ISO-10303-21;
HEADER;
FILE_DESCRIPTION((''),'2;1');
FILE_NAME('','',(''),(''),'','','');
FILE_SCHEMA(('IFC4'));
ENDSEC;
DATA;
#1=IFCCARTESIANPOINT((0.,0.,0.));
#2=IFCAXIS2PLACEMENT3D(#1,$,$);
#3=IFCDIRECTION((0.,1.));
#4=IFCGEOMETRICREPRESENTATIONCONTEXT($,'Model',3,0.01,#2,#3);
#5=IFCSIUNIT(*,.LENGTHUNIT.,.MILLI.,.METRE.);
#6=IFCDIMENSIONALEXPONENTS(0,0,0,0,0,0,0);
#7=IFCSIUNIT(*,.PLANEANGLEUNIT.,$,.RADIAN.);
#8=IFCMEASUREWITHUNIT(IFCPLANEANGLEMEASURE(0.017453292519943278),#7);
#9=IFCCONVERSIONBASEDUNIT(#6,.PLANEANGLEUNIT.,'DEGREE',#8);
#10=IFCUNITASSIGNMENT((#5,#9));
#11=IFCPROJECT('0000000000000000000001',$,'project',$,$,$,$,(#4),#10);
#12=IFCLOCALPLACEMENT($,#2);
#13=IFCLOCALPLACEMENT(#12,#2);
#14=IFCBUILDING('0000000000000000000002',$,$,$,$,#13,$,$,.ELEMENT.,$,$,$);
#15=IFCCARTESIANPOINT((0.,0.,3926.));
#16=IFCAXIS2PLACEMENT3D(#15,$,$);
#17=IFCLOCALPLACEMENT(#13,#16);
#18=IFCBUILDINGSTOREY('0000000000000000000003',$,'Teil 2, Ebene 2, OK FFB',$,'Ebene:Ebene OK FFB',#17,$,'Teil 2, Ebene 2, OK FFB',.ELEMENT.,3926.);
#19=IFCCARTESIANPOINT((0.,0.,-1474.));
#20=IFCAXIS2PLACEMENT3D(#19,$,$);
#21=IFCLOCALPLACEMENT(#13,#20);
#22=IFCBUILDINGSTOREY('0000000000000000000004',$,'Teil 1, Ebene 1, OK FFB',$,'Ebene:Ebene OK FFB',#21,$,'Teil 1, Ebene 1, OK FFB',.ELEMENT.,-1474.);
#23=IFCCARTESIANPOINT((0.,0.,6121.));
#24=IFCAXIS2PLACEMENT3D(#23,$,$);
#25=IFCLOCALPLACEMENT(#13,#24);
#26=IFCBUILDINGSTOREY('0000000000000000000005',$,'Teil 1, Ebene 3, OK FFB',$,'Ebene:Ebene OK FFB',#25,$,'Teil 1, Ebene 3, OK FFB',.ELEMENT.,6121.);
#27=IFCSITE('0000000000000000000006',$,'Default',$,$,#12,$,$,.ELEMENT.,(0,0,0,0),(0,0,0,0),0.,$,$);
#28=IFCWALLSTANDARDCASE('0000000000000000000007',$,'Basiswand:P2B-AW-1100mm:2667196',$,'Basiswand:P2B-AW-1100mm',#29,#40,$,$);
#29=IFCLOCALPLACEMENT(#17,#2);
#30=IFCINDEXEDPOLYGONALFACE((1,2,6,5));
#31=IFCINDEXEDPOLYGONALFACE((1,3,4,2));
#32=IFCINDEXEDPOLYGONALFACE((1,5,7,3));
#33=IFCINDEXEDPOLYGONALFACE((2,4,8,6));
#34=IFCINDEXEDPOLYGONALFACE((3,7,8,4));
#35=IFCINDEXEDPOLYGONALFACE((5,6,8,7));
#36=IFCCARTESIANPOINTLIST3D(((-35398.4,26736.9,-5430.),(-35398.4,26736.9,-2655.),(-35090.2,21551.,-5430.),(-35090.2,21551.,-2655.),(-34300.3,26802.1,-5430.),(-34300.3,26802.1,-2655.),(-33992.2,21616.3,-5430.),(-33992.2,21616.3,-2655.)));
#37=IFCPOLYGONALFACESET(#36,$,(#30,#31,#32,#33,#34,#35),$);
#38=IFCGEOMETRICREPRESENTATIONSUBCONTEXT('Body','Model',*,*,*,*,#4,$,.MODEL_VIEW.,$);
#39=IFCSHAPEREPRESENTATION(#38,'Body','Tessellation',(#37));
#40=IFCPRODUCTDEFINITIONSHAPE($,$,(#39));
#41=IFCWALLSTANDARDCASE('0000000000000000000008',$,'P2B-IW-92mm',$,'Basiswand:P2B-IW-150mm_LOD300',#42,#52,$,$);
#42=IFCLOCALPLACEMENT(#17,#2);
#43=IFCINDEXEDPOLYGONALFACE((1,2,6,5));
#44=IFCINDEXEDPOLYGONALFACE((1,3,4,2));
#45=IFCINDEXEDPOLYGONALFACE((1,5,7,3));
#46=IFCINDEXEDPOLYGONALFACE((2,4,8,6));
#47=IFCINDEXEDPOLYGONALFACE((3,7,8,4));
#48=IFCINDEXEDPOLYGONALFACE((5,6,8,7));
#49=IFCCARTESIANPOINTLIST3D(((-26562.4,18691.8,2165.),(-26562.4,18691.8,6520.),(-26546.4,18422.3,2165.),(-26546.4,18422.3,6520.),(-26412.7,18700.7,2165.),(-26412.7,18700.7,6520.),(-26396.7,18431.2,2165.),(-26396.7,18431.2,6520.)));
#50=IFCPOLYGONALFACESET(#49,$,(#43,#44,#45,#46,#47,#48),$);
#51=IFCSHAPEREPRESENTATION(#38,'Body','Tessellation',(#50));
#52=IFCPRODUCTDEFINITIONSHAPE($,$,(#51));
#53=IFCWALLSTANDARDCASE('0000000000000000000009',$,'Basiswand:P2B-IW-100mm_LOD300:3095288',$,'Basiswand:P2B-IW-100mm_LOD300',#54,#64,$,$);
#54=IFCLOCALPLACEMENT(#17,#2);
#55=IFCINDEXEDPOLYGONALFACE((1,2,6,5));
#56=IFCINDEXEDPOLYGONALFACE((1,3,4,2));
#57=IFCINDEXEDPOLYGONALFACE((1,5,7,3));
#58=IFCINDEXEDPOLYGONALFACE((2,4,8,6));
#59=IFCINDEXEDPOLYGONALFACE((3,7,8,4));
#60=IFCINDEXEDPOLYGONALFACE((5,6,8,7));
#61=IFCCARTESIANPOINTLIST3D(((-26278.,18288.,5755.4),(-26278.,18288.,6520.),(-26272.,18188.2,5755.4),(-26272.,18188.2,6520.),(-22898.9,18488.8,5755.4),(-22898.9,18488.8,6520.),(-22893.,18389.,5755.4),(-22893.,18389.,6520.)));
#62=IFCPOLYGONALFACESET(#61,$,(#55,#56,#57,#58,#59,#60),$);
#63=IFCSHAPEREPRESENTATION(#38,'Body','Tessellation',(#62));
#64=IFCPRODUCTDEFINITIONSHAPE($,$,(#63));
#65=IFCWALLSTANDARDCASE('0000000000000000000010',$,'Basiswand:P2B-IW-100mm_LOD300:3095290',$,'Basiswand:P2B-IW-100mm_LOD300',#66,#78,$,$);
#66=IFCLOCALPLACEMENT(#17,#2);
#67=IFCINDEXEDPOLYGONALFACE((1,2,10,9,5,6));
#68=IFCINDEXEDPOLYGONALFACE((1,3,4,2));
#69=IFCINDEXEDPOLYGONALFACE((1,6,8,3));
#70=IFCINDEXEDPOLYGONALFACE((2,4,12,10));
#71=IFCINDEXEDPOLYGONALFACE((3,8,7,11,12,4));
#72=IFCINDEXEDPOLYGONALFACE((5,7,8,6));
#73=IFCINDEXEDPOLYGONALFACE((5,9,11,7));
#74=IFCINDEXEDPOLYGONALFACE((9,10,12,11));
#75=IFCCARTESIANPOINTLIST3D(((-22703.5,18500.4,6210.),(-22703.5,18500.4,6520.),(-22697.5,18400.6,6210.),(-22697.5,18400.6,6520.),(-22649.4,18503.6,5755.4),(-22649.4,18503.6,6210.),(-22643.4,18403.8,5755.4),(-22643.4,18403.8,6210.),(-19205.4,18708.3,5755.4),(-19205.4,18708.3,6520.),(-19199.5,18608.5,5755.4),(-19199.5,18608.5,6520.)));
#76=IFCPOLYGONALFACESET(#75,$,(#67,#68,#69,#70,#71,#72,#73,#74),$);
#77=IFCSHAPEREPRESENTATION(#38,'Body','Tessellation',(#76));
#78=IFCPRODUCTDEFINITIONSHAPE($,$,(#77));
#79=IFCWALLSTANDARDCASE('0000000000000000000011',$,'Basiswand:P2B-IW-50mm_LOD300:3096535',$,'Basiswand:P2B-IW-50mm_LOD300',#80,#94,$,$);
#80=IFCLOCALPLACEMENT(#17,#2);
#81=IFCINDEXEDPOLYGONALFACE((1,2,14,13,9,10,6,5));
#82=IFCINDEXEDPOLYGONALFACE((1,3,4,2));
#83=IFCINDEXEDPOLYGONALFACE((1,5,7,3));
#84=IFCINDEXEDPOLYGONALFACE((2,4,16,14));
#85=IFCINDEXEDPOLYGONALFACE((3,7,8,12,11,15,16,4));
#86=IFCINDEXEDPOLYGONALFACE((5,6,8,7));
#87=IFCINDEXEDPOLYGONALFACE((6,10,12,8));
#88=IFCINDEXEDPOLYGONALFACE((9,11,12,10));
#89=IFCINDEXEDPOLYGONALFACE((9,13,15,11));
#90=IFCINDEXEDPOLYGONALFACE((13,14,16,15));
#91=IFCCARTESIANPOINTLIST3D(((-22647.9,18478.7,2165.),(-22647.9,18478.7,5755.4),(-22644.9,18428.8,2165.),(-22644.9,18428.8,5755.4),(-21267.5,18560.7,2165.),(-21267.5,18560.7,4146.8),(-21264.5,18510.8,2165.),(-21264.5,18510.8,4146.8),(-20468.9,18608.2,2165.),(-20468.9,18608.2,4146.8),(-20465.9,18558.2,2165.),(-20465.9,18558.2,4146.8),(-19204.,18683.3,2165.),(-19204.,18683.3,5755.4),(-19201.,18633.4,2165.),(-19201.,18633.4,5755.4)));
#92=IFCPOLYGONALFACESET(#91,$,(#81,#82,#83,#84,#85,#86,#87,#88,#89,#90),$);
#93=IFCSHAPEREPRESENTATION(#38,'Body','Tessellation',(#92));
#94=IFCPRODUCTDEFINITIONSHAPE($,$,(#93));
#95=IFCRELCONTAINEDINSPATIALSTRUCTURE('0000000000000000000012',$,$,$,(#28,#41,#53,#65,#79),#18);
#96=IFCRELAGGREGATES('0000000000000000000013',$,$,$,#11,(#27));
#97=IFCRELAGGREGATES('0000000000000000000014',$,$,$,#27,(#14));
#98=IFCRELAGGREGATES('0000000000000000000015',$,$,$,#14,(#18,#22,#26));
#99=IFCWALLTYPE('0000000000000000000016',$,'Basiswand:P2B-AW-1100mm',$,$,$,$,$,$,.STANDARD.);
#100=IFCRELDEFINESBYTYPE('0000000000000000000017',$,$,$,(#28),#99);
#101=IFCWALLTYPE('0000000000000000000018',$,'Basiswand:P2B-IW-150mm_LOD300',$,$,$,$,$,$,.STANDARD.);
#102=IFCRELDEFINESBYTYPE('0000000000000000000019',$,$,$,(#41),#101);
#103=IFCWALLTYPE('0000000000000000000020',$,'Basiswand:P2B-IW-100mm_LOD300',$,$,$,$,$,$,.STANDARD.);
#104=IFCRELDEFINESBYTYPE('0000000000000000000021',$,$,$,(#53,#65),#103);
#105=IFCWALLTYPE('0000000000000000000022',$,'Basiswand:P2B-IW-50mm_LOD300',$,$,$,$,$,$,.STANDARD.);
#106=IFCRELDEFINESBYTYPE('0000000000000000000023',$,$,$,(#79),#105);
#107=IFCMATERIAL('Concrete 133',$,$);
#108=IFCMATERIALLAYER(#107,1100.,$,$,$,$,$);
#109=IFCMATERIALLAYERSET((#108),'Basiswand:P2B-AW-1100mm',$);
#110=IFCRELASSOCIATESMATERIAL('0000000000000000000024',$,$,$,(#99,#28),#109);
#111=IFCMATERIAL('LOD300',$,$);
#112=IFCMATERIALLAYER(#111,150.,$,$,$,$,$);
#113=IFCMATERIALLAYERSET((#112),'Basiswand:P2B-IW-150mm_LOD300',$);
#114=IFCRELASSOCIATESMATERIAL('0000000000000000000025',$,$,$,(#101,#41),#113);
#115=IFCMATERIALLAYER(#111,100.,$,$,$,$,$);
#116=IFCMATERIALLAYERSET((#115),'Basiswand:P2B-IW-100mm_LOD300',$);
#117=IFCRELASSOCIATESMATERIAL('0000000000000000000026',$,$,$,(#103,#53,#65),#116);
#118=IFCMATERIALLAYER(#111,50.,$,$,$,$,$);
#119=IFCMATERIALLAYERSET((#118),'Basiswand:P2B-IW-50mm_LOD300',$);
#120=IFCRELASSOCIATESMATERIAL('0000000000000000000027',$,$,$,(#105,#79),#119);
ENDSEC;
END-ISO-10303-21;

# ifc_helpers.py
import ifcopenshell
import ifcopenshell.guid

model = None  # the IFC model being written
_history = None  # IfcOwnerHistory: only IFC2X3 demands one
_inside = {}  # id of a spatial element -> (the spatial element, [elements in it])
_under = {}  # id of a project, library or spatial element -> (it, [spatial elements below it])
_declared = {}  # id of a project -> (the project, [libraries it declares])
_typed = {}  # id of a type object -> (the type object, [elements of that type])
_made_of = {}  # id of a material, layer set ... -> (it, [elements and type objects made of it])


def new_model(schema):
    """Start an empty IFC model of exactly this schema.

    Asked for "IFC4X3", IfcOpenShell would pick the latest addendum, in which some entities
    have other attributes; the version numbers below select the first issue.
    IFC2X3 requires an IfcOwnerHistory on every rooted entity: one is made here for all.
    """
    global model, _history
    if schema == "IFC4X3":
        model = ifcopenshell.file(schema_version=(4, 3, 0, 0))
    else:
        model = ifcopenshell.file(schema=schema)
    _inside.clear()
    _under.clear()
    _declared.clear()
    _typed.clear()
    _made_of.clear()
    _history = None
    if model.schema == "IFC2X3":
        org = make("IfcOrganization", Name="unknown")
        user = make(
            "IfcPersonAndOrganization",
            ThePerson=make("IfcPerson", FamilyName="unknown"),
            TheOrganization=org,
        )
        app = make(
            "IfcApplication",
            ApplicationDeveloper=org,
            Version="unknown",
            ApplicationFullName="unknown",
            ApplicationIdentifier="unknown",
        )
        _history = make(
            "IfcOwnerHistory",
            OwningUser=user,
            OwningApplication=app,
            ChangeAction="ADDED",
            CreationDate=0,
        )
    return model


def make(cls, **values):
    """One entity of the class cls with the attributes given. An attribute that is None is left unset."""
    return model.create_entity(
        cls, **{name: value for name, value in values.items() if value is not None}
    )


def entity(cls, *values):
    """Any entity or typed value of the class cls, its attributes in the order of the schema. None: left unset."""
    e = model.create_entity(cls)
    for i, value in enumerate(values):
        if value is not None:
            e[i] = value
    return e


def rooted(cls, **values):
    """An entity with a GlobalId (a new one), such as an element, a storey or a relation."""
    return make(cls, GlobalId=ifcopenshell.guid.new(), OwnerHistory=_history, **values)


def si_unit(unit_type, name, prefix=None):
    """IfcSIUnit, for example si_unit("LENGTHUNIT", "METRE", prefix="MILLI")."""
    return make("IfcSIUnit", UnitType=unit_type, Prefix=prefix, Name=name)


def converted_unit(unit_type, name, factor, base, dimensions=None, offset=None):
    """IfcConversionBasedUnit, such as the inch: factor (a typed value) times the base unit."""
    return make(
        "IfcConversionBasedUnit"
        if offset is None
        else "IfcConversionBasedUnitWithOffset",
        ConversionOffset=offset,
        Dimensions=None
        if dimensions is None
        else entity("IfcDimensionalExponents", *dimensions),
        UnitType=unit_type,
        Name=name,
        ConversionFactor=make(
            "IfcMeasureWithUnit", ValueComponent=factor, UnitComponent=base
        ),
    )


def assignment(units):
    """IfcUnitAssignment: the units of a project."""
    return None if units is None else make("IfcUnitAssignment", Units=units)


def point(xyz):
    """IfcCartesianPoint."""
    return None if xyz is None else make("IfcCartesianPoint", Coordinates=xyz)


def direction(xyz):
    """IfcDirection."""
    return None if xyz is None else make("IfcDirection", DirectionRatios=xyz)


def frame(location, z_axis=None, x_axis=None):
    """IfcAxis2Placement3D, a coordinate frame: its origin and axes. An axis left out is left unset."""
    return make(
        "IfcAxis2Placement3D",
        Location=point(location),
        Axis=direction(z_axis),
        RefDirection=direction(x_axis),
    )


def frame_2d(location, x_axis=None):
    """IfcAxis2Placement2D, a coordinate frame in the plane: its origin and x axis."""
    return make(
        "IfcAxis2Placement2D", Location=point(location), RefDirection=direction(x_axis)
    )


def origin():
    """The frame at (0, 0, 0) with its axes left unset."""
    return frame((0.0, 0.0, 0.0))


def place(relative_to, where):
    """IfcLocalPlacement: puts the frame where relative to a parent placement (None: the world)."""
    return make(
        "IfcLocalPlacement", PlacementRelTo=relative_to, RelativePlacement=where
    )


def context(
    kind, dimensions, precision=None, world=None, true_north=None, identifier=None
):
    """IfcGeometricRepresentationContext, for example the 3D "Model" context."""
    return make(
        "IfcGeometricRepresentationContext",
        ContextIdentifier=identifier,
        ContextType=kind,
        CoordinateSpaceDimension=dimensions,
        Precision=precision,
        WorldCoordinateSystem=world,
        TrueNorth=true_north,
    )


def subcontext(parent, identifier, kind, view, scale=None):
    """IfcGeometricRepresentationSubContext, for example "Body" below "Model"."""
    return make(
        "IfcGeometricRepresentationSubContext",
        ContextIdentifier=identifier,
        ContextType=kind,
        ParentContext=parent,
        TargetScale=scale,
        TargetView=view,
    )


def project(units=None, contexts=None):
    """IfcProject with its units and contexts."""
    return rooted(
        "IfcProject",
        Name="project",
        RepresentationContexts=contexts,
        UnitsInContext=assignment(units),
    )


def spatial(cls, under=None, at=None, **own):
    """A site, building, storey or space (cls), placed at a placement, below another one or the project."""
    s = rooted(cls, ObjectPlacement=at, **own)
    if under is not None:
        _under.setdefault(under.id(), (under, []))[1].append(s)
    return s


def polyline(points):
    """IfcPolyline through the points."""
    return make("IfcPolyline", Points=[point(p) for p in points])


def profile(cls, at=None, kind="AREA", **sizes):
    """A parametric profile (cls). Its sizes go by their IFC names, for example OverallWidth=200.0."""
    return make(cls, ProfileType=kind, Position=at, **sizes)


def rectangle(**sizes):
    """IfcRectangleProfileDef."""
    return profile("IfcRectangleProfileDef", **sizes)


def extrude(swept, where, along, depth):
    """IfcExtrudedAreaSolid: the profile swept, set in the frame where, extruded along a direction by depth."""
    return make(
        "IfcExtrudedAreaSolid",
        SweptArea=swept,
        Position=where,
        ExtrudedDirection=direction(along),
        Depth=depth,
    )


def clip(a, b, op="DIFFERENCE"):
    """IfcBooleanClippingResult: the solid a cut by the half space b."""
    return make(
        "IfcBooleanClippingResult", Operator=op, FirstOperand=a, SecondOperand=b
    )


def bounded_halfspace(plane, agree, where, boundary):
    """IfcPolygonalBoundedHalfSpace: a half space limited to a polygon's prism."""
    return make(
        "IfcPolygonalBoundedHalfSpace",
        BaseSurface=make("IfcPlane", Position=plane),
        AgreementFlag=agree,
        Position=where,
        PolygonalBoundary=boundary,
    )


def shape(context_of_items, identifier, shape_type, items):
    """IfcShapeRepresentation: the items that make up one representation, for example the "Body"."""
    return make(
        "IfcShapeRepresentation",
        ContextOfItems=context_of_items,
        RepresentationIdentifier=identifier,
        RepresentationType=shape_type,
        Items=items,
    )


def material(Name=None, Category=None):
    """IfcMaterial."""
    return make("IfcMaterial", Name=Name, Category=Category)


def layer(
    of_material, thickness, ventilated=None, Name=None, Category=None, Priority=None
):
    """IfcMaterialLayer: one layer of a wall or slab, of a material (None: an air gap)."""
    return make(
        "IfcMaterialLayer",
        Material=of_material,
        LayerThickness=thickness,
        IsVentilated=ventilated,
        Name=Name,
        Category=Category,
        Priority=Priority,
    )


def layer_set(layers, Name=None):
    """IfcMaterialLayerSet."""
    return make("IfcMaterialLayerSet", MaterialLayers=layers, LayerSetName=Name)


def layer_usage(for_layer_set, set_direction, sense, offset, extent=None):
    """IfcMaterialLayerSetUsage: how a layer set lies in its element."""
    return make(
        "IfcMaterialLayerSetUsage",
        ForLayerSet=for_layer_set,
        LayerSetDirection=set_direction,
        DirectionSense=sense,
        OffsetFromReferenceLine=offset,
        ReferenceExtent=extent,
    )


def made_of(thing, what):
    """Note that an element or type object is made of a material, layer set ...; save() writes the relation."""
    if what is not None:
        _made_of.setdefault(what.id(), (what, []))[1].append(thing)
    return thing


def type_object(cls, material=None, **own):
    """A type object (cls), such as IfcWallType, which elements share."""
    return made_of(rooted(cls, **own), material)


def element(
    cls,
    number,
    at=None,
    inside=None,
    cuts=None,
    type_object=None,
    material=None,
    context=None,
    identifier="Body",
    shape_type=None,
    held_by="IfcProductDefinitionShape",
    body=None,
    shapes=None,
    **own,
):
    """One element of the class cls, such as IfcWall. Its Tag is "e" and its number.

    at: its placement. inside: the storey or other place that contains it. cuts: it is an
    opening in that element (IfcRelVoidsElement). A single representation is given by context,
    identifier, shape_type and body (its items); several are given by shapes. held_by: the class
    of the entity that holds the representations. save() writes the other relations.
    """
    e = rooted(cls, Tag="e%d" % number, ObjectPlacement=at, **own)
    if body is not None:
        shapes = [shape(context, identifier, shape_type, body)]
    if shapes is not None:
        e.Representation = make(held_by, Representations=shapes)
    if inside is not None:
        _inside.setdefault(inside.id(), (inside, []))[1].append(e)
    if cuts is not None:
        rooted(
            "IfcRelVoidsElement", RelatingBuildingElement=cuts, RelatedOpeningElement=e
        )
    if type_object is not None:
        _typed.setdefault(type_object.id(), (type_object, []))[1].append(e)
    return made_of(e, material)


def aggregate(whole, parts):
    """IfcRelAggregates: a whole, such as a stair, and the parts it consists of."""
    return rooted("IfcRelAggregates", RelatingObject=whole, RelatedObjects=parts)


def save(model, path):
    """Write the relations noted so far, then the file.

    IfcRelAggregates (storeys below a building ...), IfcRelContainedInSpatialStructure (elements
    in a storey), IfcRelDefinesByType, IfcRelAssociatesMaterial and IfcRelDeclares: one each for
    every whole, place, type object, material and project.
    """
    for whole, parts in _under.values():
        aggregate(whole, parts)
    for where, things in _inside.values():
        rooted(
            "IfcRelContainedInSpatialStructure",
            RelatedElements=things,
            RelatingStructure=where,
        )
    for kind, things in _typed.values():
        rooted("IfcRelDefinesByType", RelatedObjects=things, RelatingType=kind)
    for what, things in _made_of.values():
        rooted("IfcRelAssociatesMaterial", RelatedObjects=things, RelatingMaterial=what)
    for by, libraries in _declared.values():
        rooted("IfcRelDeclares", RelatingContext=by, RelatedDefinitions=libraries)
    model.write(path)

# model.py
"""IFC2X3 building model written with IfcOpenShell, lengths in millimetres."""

from ifc_helpers import new_model, entity, si_unit, converted_unit, direction, frame, frame_2d, origin, place, context, subcontext, project, spatial, polyline, rectangle, extrude, clip, bounded_halfspace, material, layer, layer_set, layer_usage, type_object, element, save


model = new_model("IFC2X3")

# Units and contexts
model_context = context("Model", 3, precision=0.01, world=origin(), true_north=direction((0.0, 1.0)))
body_context = subcontext(model_context, "Body", "Model", "MODEL_VIEW")
ifc_project = project(units=[si_unit("LENGTHUNIT", "METRE", prefix="MILLI"), converted_unit("PLANEANGLEUNIT", "DEGREE", entity("IfcPlaneAngleMeasure", 0.017453292519943278), si_unit("PLANEANGLEUNIT", "RADIAN"), dimensions=[0, 0, 0, 0, 0, 0, 0])], contexts=[model_context])

# Site, building, storey
site_placement = place(None, origin())
site = spatial("IfcSite", under=ifc_project, at=site_placement, Name="Default", CompositionType="ELEMENT", RefLatitude=(0, 0, 0, 0), RefLongitude=(0, 0, 0, 0), RefElevation=0.0)
building_placement = place(site_placement, origin())
building = spatial("IfcBuilding", under=site, at=building_placement, CompositionType="ELEMENT")
storey_1_placement = place(building_placement, frame((0.0, 0.0, 3926.0)))
storey_1 = spatial("IfcBuildingStorey", under=building, at=storey_1_placement, Name="Teil 2, Ebene 2, OK FFB", ObjectType="Ebene:Ebene OK FFB", LongName="Teil 2, Ebene 2, OK FFB", CompositionType="ELEMENT", Elevation=3926.0)

# Shared definitions
storey_2_placement = place(building_placement, frame((0.0, 0.0, -1474.0)))
storey_2 = spatial("IfcBuildingStorey", under=building, at=storey_2_placement, Name="Teil 1, Ebene 1, OK FFB", ObjectType="Ebene:Ebene OK FFB", LongName="Teil 1, Ebene 1, OK FFB", CompositionType="ELEMENT", Elevation=-1474.0)

# Shared definitions
storey_3_placement = place(building_placement, frame((0.0, 0.0, 6121.0)))
storey_3 = spatial("IfcBuildingStorey", under=building, at=storey_3_placement, Name="Teil 1, Ebene 3, OK FFB", ObjectType="Ebene:Ebene OK FFB", LongName="Teil 1, Ebene 3, OK FFB", CompositionType="ELEMENT", Elevation=6121.0)

# Walls
ifc_material_1 = material(Name="Concrete 133")
ifc_layer_1 = layer(ifc_material_1, 1100.0)
ifc_layer_set_1 = layer_set([ifc_layer_1], Name="Basiswand:P2B-AW-1100mm")
ifc_layer_usage_1 = layer_usage(ifc_layer_set_1, "AXIS2", "NEGATIVE", 550.0)
wall_type_1 = type_object("IfcWallType", Name="Basiswand:P2B-AW-1100mm", PredefinedType="STANDARD", material=ifc_layer_set_1)
wall_1_placement = place(storey_1_placement, frame((-34541.2, 21583.6, -5430.0), z_axis=(0.0, 0.0, 1.0), x_axis=(-0.059319, 0.998239, 0.0)))
element("IfcWallStandardCase", 1, at=wall_1_placement, inside=storey_1, type_object=wall_type_1, material=ifc_layer_usage_1, Name="Basiswand:P2B-AW-1100mm:2667196", ObjectType="Basiswand:P2B-AW-1100mm", context=body_context, shape_type="SweptSolid", body=[
    extrude(rectangle(XDim=5195.0, YDim=1100.0, at=frame_2d((2597.5, 0.0), x_axis=(-1.0, 0.0))), origin(), (0.0, 0.0, 1.0), 2775.0),
])
ifc_material_2 = material(Name="LOD300")
ifc_layer_2 = layer(ifc_material_2, 150.0)
ifc_layer_set_2 = layer_set([ifc_layer_2], Name="Basiswand:P2B-IW-150mm_LOD300")
ifc_layer_usage_2 = layer_usage(ifc_layer_set_2, "AXIS2", "POSITIVE", -75.0)
wall_type_2 = type_object("IfcWallType", Name="Basiswand:P2B-IW-150mm_LOD300", PredefinedType="STANDARD", material=ifc_layer_set_2)
wall_2_placement = place(storey_1_placement, frame((-26471.5, 18426.8, 2165.0), z_axis=(0.0, 0.0, 1.0), x_axis=(-0.059319, 0.998239, 0.0)))
element("IfcWallStandardCase", 2, at=wall_2_placement, inside=storey_1, type_object=wall_type_2, material=ifc_layer_usage_2, Name="P2B-IW-92mm", ObjectType="Basiswand:P2B-IW-150mm_LOD300", context=body_context, shape_type="SweptSolid", body=[
    extrude(rectangle(XDim=270.0, YDim=150.0, at=frame_2d((135.0, 0.0), x_axis=(-1.0, 0.0))), origin(), (0.0, 0.0, 1.0), 4355.0),
])
ifc_layer_3 = layer(ifc_material_2, 100.0)
ifc_layer_set_3 = layer_set([ifc_layer_3], Name="Basiswand:P2B-IW-100mm_LOD300")
ifc_layer_usage_3 = layer_usage(ifc_layer_set_3, "AXIS2", "POSITIVE", -50.0)
wall_type_3 = type_object("IfcWallType", Name="Basiswand:P2B-IW-100mm_LOD300", PredefinedType="STANDARD", material=ifc_layer_set_3)
wall_3_placement = place(storey_1_placement, frame((-22896.0, 18438.9, 5755.4), z_axis=(0.0, 0.0, 1.0), x_axis=(-0.998239, -0.059319, 0.0)))
element("IfcWallStandardCase", 3, at=wall_3_placement, inside=storey_1, type_object=wall_type_3, material=ifc_layer_usage_3, Name="Basiswand:P2B-IW-100mm_LOD300:3095288", ObjectType="Basiswand:P2B-IW-100mm_LOD300", context=body_context, shape_type="SweptSolid", body=[
    extrude(rectangle(XDim=3385.0, YDim=100.0, at=frame_2d((1692.5, 0.0), x_axis=(-1.0, 0.0))), origin(), (0.0, 0.0, 1.0), 764.6),
])
ifc_layer_usage_4 = layer_usage(ifc_layer_set_3, "AXIS2", "POSITIVE", -50.0)
wall_4_placement = place(storey_1_placement, frame((-19202.5, 18658.4, 5755.4), z_axis=(0.0, 0.0, 1.0), x_axis=(-0.998239, -0.059319, 0.0)))
element("IfcWallStandardCase", 4, at=wall_4_placement, inside=storey_1, type_object=wall_type_3, material=ifc_layer_usage_4, Name="Basiswand:P2B-IW-100mm_LOD300:3095290", ObjectType="Basiswand:P2B-IW-100mm_LOD300", context=body_context, shape_type="Clipping", body=[
    clip(clip(extrude(rectangle(XDim=3504.2, YDim=100.0, at=frame_2d((1752.1, 0.0), x_axis=(-1.0, 0.0))), origin(), (0.0, 0.0, 1.0), 764.6), bounded_halfspace(frame((3450.0, -50.0, 454.6), z_axis=(0.0, 0.0, 1.0), x_axis=(0.0, -1.0, 0.0)), True, frame((3450.0, -50.0, 454.6), z_axis=(0.0, 0.0, 1.0), x_axis=(0.0, -1.0, 0.0)), polyline([(0.0, 0.0), (0.0, 54.2), (-100.0, 54.2), (-100.0, 0.0), (0.0, 0.0)]))), bounded_halfspace(frame((3450.0, 50.0, 454.6), z_axis=(-1.0, 0.0, 0.0), x_axis=(0.0, 0.0, -1.0)), True, frame((3450.0, 50.0, 454.6), z_axis=(-1.0, 0.0, 0.0), x_axis=(0.0, 0.0, -1.0)), polyline([(0.0, 0.0), (454.6, 0.0), (454.6, 100.0), (0.0, 100.0), (0.0, 0.0)]))),
])

# Wall, opening
ifc_layer_4 = layer(ifc_material_2, 50.0)
ifc_layer_set_4 = layer_set([ifc_layer_4], Name="Basiswand:P2B-IW-50mm_LOD300")
ifc_layer_usage_5 = layer_usage(ifc_layer_set_4, "AXIS2", "POSITIVE", -25.0)
wall_type_4 = type_object("IfcWallType", Name="Basiswand:P2B-IW-50mm_LOD300", PredefinedType="STANDARD", material=ifc_layer_set_4)
wall_5_placement = place(storey_1_placement, frame((-19202.5, 18658.4, 2165.0), z_axis=(0.0, 0.0, 1.0), x_axis=(-0.998239, -0.059319, 0.0)))
wall_5 = element("IfcWallStandardCase", 5, at=wall_5_placement, inside=storey_1, type_object=wall_type_4, material=ifc_layer_usage_5, Name="Basiswand:P2B-IW-50mm_LOD300:3096535", ObjectType="Basiswand:P2B-IW-50mm_LOD300", context=body_context, shape_type="Clipping", body=[
    clip(extrude(rectangle(XDim=3450.0, YDim=50.0, at=frame_2d((1725.0, 0.0), x_axis=(-1.0, 0.0))), origin(), (0.0, 0.0, 1.0), 3590.4), bounded_halfspace(frame((3450.0, -25.0, 3590.4), z_axis=(-1.0, 0.0, 0.0), x_axis=(0.0, 0.0, -1.0)), True, frame((3450.0, -25.0, 3590.4), z_axis=(-1.0, 0.0, 0.0), x_axis=(0.0, 0.0, -1.0)), polyline([(0.0, 0.0), (0.0, -50.0), (3590.4, -50.0), (3590.4, 0.0), (0.0, 0.0)]))),
])
opening_1_placement = place(wall_5_placement, origin())
element("IfcOpeningElement", 6, at=opening_1_placement, cuts=wall_5, ObjectType="Opening", context=body_context, shape_type="SweptSolid", body=[
    extrude(rectangle(XDim=1981.8, YDim=800.0, at=frame_2d((0.0, 0.0), x_axis=(1.0, 0.0))), frame((1667.1, -25.0, 990.9), z_axis=(0.0, 1.0, 0.0), x_axis=(0.0, 0.0, -1.0)), (0.0, 0.0, 1.0), 50.0),
])

save(model, "model.ifc")
